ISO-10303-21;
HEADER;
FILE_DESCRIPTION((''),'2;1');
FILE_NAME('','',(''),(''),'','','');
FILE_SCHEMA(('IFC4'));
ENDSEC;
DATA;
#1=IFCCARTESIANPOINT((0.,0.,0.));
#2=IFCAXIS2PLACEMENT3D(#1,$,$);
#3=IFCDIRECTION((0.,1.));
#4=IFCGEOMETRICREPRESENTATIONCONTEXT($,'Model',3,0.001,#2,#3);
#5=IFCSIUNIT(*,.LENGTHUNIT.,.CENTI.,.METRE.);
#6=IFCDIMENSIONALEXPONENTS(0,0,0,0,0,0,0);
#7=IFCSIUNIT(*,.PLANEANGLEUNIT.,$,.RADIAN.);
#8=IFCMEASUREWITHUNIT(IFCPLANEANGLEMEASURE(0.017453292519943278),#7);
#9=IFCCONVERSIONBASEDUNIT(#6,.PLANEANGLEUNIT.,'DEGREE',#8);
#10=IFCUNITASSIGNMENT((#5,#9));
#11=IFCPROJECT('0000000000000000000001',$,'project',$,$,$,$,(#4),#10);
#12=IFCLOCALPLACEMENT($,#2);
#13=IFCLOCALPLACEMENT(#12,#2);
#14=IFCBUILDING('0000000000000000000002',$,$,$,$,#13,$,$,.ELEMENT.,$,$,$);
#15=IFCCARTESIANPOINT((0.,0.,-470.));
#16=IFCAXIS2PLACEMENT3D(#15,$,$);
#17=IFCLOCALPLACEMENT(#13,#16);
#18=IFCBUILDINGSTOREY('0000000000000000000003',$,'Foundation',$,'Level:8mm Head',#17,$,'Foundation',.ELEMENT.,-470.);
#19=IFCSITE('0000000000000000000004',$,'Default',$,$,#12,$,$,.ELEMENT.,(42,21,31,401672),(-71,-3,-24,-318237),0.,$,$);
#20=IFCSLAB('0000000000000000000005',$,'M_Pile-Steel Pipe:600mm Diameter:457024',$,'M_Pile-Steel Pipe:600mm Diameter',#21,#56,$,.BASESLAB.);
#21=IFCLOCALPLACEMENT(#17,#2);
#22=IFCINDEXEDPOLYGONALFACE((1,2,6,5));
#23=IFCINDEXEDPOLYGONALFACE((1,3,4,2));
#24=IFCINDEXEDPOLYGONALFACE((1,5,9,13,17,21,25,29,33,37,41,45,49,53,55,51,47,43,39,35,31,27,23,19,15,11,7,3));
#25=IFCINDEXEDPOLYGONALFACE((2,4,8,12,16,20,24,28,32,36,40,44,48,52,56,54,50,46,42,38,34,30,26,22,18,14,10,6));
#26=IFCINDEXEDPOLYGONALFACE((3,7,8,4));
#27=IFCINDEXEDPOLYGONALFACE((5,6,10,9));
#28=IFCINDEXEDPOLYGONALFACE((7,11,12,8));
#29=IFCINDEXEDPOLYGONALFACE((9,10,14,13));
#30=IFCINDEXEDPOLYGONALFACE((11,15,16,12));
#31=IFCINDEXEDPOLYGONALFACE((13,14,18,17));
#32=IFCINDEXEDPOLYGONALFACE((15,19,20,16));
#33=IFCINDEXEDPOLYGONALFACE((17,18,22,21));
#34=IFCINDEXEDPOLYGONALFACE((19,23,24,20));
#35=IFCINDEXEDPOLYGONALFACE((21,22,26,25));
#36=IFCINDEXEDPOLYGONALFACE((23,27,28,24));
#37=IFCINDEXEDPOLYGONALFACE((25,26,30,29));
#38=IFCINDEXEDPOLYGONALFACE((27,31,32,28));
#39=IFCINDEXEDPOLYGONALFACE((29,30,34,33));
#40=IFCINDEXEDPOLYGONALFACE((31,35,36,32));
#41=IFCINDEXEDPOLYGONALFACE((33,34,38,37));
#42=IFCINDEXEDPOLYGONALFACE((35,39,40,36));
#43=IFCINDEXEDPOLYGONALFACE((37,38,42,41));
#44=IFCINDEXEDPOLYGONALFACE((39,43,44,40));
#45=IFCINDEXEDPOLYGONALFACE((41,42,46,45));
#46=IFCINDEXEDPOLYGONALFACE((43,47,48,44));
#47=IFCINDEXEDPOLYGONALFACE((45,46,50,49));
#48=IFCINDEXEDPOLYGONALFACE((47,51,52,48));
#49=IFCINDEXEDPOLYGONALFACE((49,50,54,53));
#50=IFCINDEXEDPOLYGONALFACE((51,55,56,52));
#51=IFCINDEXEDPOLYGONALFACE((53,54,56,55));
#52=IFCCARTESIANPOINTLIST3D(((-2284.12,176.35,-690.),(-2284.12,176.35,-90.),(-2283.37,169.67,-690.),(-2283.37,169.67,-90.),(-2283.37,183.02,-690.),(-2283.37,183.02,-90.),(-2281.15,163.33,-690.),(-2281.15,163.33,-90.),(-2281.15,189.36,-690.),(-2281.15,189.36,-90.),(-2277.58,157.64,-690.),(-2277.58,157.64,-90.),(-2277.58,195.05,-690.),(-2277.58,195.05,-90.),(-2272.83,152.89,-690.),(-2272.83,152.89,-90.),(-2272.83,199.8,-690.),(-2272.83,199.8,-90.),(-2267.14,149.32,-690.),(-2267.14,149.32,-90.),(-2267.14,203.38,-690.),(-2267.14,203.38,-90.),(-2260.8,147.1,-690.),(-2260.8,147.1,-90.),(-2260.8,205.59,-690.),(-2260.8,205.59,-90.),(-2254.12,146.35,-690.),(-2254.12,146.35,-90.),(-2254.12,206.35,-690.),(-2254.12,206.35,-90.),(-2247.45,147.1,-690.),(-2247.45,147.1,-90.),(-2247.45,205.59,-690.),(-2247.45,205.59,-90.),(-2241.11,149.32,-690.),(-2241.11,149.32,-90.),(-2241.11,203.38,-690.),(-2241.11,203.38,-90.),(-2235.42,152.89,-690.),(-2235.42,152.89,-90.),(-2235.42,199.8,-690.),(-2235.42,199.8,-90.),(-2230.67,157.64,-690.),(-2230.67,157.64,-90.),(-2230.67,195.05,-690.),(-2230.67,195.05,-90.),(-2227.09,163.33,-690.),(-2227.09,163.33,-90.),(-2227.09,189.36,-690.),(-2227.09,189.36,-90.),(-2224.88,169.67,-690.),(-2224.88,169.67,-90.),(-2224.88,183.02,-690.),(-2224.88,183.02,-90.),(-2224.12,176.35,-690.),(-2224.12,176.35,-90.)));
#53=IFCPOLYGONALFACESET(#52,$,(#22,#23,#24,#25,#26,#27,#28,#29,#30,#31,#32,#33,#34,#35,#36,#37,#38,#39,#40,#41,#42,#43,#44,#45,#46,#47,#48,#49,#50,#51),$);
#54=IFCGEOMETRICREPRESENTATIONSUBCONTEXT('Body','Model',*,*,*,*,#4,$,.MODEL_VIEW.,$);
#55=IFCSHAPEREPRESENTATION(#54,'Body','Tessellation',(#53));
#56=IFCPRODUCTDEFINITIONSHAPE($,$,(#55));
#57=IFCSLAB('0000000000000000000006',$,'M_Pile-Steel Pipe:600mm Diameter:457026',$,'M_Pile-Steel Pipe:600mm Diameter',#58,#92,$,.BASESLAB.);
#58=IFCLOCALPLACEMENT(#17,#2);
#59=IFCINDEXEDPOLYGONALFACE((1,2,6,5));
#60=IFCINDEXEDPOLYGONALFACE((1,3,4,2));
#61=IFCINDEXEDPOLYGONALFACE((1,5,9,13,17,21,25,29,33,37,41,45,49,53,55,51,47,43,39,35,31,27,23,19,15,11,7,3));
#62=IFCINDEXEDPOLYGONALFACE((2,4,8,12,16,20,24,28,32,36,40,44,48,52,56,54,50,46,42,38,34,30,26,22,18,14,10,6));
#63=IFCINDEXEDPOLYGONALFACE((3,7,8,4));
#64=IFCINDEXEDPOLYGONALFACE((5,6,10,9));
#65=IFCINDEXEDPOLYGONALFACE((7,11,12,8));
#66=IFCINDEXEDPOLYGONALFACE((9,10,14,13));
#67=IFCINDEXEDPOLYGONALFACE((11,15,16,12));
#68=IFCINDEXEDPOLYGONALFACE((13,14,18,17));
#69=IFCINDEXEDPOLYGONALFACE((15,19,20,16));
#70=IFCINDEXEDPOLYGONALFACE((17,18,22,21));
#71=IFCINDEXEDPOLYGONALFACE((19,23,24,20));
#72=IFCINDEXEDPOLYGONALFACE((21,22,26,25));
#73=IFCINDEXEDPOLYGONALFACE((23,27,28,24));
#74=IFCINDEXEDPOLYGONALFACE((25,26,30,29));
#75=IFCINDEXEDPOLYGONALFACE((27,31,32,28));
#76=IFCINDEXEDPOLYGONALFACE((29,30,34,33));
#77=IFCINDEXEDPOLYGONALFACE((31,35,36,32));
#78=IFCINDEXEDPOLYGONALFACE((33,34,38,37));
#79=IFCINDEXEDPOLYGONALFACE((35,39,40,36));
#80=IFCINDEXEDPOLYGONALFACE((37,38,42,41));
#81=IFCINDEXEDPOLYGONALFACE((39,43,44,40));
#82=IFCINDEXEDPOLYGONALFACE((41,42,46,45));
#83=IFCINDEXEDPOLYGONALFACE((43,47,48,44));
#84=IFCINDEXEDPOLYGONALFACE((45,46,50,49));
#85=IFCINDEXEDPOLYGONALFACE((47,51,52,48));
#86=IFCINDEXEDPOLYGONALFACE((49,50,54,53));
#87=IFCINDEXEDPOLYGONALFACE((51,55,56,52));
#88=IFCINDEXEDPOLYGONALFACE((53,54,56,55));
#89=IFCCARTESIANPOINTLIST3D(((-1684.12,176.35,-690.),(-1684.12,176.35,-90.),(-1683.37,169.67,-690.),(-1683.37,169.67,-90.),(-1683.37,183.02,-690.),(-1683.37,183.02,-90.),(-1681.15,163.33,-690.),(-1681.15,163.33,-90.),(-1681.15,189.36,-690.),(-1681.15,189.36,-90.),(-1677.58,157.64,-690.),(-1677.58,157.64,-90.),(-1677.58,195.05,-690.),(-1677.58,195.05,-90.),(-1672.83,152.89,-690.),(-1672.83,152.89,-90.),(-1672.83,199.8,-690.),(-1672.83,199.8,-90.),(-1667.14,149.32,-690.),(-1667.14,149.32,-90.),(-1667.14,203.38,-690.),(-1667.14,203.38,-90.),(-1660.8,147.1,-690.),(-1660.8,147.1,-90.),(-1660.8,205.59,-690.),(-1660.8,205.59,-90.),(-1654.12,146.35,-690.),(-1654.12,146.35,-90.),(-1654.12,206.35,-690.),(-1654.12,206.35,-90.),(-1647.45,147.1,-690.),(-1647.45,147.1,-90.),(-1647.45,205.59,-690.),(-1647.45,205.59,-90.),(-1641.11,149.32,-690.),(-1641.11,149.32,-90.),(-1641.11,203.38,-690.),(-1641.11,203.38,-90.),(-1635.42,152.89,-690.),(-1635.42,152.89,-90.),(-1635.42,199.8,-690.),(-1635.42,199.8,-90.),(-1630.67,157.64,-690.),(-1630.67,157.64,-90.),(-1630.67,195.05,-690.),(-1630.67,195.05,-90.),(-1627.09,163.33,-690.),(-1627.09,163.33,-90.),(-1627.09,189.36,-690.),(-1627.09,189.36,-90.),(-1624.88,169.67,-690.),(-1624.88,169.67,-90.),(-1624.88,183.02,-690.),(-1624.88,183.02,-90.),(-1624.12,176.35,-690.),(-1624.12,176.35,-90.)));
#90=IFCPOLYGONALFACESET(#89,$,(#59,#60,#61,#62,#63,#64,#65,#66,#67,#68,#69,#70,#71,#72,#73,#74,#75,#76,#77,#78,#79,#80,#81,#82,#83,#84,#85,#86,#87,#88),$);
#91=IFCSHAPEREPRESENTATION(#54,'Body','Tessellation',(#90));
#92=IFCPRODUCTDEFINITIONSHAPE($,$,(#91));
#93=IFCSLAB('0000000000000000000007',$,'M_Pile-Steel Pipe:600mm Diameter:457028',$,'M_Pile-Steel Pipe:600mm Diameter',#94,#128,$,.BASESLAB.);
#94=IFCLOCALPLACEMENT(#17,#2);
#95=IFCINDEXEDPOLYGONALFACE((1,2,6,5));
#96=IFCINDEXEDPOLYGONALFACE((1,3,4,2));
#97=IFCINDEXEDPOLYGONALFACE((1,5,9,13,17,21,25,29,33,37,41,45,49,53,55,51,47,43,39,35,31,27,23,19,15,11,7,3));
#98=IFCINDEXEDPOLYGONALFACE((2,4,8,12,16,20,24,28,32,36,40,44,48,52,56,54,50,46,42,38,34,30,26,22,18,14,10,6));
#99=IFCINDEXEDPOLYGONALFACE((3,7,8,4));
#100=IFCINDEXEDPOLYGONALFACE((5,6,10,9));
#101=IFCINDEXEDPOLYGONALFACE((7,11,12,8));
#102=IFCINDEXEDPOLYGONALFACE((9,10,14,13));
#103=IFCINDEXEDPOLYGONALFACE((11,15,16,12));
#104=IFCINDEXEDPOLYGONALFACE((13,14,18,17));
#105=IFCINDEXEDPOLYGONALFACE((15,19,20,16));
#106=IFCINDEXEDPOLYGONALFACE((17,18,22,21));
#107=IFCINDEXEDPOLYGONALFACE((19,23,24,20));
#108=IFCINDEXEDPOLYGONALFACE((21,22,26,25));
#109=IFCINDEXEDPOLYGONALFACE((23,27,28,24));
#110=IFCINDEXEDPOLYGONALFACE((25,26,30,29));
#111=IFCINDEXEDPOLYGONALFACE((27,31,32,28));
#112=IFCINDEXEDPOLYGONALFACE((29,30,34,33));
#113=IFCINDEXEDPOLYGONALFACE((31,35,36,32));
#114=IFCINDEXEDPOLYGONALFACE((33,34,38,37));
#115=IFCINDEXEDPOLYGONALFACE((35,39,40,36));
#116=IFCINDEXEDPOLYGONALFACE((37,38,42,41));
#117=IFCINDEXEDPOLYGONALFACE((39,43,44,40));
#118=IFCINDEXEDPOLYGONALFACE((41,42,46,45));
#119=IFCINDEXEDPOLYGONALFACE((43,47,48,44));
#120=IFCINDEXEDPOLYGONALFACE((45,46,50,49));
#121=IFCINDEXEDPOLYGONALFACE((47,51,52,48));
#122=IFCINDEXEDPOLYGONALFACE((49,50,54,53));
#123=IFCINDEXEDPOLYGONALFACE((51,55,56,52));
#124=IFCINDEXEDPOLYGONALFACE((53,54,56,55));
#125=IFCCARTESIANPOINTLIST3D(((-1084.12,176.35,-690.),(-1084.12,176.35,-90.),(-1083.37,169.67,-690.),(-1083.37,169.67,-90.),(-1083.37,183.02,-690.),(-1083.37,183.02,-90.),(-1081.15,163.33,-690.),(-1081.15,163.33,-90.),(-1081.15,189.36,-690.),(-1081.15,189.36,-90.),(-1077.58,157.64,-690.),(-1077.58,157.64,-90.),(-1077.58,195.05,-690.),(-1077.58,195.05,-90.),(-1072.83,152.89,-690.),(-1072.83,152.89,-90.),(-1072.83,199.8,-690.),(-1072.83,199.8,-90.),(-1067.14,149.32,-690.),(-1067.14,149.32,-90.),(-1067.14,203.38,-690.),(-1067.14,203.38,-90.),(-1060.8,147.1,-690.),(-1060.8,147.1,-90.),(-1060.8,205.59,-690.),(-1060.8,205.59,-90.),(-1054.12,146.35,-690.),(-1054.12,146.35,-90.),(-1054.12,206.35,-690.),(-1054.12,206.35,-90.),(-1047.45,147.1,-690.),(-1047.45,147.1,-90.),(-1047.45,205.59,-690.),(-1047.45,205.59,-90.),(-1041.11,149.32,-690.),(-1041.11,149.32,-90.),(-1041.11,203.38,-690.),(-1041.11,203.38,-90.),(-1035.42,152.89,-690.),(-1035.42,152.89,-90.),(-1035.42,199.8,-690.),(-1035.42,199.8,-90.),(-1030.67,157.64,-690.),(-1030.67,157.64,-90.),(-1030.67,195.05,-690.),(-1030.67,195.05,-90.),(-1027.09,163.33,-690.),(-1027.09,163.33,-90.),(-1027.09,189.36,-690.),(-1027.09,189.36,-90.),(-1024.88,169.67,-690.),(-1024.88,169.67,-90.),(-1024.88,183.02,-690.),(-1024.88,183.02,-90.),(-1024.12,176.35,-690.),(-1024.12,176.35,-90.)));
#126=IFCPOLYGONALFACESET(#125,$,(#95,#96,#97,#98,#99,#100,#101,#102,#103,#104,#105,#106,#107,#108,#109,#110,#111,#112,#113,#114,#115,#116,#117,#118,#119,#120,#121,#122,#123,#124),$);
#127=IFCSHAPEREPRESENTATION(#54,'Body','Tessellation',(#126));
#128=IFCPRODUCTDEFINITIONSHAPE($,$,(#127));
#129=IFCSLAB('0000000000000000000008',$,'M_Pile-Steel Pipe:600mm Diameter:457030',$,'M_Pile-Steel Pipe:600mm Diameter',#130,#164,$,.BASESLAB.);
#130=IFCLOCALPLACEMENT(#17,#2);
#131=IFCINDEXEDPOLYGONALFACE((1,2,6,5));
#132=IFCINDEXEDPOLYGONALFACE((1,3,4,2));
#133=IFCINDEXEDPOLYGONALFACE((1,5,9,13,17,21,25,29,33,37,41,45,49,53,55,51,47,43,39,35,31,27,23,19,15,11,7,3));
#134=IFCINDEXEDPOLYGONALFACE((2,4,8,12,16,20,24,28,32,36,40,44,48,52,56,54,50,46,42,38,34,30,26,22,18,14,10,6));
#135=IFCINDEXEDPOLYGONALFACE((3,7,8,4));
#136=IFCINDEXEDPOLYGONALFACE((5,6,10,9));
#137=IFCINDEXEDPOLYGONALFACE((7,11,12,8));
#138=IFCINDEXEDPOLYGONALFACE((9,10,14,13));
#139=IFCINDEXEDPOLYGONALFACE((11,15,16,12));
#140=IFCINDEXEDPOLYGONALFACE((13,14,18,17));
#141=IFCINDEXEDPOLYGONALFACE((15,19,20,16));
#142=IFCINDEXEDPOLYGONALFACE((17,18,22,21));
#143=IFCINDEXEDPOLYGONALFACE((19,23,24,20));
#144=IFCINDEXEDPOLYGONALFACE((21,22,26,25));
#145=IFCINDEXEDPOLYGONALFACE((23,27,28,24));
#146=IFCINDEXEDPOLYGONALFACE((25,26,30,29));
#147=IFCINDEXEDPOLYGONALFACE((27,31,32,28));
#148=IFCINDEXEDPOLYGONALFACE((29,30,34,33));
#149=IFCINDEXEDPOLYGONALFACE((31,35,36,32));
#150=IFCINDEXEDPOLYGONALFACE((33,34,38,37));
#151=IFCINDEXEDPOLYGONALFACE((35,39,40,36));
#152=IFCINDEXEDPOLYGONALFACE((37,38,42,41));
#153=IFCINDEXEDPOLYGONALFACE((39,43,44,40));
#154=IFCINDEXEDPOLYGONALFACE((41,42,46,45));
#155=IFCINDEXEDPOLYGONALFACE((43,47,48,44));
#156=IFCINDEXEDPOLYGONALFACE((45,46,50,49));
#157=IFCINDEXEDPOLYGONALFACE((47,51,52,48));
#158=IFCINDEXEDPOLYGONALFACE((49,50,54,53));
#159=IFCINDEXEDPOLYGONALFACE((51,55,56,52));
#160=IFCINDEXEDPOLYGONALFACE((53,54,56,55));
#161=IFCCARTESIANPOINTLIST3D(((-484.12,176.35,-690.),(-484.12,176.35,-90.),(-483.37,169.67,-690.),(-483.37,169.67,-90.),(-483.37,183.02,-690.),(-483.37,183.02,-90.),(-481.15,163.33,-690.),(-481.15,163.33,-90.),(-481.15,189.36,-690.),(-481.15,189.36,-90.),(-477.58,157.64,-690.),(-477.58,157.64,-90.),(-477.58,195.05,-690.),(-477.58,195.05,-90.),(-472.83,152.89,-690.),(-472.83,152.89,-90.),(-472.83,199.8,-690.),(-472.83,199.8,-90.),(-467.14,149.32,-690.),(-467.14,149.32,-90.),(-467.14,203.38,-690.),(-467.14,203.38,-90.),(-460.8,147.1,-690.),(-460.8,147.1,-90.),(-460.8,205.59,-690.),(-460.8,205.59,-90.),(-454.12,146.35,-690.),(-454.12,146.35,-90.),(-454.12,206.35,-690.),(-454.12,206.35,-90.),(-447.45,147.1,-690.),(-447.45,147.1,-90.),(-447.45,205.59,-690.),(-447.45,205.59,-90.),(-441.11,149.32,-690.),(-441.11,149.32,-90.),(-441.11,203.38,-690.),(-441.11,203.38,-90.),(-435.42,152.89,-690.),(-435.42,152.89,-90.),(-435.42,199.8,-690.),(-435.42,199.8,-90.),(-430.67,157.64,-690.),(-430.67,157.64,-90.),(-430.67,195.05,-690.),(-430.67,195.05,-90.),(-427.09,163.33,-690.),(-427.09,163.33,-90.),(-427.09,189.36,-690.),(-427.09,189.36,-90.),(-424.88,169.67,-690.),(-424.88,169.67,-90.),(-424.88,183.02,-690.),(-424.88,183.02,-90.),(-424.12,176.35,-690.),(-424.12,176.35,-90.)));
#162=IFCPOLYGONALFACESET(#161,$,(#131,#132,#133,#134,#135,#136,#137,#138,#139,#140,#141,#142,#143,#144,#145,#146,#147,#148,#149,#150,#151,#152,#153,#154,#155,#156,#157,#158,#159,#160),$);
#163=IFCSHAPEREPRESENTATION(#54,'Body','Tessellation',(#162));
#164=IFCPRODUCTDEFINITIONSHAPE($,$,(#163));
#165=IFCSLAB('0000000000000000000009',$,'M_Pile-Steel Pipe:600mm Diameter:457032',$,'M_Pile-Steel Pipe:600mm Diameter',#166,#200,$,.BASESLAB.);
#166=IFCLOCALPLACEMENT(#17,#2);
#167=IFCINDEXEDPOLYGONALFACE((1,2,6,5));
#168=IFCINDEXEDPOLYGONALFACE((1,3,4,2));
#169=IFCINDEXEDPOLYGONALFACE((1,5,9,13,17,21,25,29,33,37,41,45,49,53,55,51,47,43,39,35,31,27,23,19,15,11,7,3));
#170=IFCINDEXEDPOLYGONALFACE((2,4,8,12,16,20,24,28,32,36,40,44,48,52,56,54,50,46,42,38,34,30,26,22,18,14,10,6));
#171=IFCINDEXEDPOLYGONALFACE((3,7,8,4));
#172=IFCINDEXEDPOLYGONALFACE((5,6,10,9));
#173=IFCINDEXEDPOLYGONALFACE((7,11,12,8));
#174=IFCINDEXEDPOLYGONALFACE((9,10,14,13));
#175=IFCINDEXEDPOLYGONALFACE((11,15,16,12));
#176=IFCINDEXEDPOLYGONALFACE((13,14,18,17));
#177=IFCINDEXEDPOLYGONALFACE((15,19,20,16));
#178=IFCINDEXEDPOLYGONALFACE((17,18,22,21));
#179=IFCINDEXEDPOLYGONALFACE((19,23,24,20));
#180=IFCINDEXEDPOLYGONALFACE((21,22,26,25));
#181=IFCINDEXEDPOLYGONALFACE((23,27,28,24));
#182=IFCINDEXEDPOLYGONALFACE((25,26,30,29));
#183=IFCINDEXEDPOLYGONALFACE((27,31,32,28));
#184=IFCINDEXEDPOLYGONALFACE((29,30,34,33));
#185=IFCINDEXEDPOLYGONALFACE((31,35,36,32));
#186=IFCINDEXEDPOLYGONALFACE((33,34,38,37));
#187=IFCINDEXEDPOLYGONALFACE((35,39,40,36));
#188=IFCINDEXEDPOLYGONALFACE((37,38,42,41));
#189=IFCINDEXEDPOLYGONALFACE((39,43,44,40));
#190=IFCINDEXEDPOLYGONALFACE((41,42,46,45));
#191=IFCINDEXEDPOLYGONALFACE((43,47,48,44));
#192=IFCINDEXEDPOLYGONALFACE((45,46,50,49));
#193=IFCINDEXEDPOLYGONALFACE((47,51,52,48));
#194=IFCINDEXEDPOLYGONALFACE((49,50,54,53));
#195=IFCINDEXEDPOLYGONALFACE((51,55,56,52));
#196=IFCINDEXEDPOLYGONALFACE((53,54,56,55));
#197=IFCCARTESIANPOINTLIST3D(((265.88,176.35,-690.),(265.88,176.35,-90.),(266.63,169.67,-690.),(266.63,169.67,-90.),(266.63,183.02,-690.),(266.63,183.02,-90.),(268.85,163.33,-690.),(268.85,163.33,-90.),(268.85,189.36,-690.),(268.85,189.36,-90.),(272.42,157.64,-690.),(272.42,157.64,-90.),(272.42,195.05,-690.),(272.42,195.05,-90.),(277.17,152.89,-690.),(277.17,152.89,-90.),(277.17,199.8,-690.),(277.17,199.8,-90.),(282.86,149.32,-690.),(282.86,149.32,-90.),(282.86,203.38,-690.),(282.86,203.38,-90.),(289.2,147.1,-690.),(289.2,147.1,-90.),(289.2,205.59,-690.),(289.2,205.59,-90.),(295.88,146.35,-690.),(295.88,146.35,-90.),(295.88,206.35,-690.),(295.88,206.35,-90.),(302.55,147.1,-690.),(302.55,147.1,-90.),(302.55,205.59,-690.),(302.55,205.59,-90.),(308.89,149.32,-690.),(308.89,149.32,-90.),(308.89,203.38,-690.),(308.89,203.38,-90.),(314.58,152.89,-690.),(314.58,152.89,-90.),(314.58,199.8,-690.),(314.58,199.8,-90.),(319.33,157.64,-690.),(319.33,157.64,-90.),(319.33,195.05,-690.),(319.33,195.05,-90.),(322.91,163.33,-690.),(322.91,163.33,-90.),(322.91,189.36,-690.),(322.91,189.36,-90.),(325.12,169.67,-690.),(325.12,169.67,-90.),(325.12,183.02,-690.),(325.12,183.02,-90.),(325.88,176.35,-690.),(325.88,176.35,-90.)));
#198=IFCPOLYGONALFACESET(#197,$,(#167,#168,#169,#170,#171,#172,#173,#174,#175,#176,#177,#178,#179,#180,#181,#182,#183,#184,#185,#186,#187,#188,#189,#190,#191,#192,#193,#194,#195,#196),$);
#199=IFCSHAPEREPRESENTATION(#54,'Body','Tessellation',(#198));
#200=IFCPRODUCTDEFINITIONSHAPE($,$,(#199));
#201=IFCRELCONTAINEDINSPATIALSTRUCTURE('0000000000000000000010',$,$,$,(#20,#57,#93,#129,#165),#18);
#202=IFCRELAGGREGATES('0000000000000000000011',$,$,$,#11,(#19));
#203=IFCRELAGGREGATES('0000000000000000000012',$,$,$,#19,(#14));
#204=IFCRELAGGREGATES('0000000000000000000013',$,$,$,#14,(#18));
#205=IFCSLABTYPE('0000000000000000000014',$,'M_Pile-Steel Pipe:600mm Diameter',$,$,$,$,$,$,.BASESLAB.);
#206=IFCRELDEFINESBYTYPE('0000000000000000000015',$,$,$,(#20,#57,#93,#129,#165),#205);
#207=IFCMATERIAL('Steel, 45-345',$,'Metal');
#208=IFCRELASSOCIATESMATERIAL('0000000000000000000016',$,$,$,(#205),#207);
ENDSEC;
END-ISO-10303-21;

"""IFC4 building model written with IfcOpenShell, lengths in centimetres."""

from ifc_helpers import new_model, entity, si_unit, converted_unit, direction, frame, origin, place, context, subcontext, project, spatial, arc, indexed_curve, outline, extrude, material, type_object, element, save


model = new_model("IFC4")

# Units and contexts
model_context = context("Model", 3, precision=0.001, world=origin(), true_north=direction((0.0, 1.0)))
body_context = subcontext(model_context, "Body", "Model", "MODEL_VIEW")
ifc_project = project(units=[si_unit("LENGTHUNIT", "METRE", prefix="CENTI"), converted_unit("PLANEANGLEUNIT", "DEGREE", entity("IfcPlaneAngleMeasure", 0.017453292519943278), si_unit("PLANEANGLEUNIT", "RADIAN"), dimensions=[0, 0, 0, 0, 0, 0, 0])], contexts=[model_context])

# Site, building, storey
site_placement = place(None, origin())
site = spatial("IfcSite", under=ifc_project, at=site_placement, Name="Default", CompositionType="ELEMENT", RefLatitude=(42, 21, 31, 401672), RefLongitude=(-71, -3, -24, -318237), RefElevation=0.0)
building_placement = place(site_placement, origin())
building = spatial("IfcBuilding", under=site, at=building_placement, CompositionType="ELEMENT")
storey_placement = place(building_placement, frame((0.0, 0.0, -470.0)))
storey = spatial("IfcBuildingStorey", under=building, at=storey_placement, Name="Foundation", ObjectType="Level:8mm Head", LongName="Foundation", CompositionType="ELEMENT", Elevation=-470.0)

# Slabs
ifc_material_1 = material(Name="Steel, 45-345", Category="Metal")
slab_type_1 = type_object("IfcSlabType", Name="M_Pile-Steel Pipe:600mm Diameter", PredefinedType="BASESLAB", material=ifc_material_1)
slab_1_placement = place(storey_placement, origin())
element("IfcSlab", 1, at=slab_1_placement, inside=storey, type_object=slab_type_1, Name="M_Pile-Steel Pipe:600mm Diameter:457024", ObjectType="M_Pile-Steel Pipe:600mm Diameter", PredefinedType="BASESLAB", context=body_context, shape_type="SweptSolid", body=[
    extrude(outline(indexed_curve([(-30.0, 0.0), (0.0, -30.0), (30.0, 0.0), (0.0, 30.0)], segments=[arc(1, 2, 3), arc(3, 4, 1)], self_intersect=False)), frame((-2254.12, 176.35, -690.0)), (0.0, 0.0, 1.0), 600.0),
])
slab_2_placement = place(storey_placement, origin())
element("IfcSlab", 2, at=slab_2_placement, inside=storey, type_object=slab_type_1, Name="M_Pile-Steel Pipe:600mm Diameter:457026", ObjectType="M_Pile-Steel Pipe:600mm Diameter", PredefinedType="BASESLAB", context=body_context, shape_type="SweptSolid", body=[
    extrude(outline(indexed_curve([(-30.0, 0.0), (0.0, -30.0), (30.0, 0.0), (0.0, 30.0)], segments=[arc(1, 2, 3), arc(3, 4, 1)], self_intersect=False)), frame((-1654.12, 176.35, -690.0)), (0.0, 0.0, 1.0), 600.0),
])
slab_3_placement = place(storey_placement, origin())
element("IfcSlab", 3, at=slab_3_placement, inside=storey, type_object=slab_type_1, Name="M_Pile-Steel Pipe:600mm Diameter:457028", ObjectType="M_Pile-Steel Pipe:600mm Diameter", PredefinedType="BASESLAB", context=body_context, shape_type="SweptSolid", body=[
    extrude(outline(indexed_curve([(-30.0, 0.0), (0.0, -30.0), (30.0, 0.0), (0.0, 30.0)], segments=[arc(1, 2, 3), arc(3, 4, 1)], self_intersect=False)), frame((-1054.12, 176.35, -690.0)), (0.0, 0.0, 1.0), 600.0),
])
slab_4_placement = place(storey_placement, origin())
element("IfcSlab", 4, at=slab_4_placement, inside=storey, type_object=slab_type_1, Name="M_Pile-Steel Pipe:600mm Diameter:457030", ObjectType="M_Pile-Steel Pipe:600mm Diameter", PredefinedType="BASESLAB", context=body_context, shape_type="SweptSolid", body=[
    extrude(outline(indexed_curve([(-30.0, 0.0), (0.0, -30.0), (30.0, 0.0), (0.0, 30.0)], segments=[arc(1, 2, 3), arc(3, 4, 1)], self_intersect=False)), frame((-454.12, 176.35, -690.0)), (0.0, 0.0, 1.0), 600.0),
])
slab_5_placement = place(storey_placement, origin())
element("IfcSlab", 5, at=slab_5_placement, inside=storey, type_object=slab_type_1, Name="M_Pile-Steel Pipe:600mm Diameter:457032", ObjectType="M_Pile-Steel Pipe:600mm Diameter", PredefinedType="BASESLAB", context=body_context, shape_type="SweptSolid", body=[
    extrude(outline(indexed_curve([(-30.0, 0.0), (0.0, -30.0), (30.0, 0.0), (0.0, 30.0)], segments=[arc(1, 2, 3), arc(3, 4, 1)], self_intersect=False)), frame((295.88, 176.35, -690.0)), (0.0, 0.0, 1.0), 600.0),
])

save(model, "model.ifc")
